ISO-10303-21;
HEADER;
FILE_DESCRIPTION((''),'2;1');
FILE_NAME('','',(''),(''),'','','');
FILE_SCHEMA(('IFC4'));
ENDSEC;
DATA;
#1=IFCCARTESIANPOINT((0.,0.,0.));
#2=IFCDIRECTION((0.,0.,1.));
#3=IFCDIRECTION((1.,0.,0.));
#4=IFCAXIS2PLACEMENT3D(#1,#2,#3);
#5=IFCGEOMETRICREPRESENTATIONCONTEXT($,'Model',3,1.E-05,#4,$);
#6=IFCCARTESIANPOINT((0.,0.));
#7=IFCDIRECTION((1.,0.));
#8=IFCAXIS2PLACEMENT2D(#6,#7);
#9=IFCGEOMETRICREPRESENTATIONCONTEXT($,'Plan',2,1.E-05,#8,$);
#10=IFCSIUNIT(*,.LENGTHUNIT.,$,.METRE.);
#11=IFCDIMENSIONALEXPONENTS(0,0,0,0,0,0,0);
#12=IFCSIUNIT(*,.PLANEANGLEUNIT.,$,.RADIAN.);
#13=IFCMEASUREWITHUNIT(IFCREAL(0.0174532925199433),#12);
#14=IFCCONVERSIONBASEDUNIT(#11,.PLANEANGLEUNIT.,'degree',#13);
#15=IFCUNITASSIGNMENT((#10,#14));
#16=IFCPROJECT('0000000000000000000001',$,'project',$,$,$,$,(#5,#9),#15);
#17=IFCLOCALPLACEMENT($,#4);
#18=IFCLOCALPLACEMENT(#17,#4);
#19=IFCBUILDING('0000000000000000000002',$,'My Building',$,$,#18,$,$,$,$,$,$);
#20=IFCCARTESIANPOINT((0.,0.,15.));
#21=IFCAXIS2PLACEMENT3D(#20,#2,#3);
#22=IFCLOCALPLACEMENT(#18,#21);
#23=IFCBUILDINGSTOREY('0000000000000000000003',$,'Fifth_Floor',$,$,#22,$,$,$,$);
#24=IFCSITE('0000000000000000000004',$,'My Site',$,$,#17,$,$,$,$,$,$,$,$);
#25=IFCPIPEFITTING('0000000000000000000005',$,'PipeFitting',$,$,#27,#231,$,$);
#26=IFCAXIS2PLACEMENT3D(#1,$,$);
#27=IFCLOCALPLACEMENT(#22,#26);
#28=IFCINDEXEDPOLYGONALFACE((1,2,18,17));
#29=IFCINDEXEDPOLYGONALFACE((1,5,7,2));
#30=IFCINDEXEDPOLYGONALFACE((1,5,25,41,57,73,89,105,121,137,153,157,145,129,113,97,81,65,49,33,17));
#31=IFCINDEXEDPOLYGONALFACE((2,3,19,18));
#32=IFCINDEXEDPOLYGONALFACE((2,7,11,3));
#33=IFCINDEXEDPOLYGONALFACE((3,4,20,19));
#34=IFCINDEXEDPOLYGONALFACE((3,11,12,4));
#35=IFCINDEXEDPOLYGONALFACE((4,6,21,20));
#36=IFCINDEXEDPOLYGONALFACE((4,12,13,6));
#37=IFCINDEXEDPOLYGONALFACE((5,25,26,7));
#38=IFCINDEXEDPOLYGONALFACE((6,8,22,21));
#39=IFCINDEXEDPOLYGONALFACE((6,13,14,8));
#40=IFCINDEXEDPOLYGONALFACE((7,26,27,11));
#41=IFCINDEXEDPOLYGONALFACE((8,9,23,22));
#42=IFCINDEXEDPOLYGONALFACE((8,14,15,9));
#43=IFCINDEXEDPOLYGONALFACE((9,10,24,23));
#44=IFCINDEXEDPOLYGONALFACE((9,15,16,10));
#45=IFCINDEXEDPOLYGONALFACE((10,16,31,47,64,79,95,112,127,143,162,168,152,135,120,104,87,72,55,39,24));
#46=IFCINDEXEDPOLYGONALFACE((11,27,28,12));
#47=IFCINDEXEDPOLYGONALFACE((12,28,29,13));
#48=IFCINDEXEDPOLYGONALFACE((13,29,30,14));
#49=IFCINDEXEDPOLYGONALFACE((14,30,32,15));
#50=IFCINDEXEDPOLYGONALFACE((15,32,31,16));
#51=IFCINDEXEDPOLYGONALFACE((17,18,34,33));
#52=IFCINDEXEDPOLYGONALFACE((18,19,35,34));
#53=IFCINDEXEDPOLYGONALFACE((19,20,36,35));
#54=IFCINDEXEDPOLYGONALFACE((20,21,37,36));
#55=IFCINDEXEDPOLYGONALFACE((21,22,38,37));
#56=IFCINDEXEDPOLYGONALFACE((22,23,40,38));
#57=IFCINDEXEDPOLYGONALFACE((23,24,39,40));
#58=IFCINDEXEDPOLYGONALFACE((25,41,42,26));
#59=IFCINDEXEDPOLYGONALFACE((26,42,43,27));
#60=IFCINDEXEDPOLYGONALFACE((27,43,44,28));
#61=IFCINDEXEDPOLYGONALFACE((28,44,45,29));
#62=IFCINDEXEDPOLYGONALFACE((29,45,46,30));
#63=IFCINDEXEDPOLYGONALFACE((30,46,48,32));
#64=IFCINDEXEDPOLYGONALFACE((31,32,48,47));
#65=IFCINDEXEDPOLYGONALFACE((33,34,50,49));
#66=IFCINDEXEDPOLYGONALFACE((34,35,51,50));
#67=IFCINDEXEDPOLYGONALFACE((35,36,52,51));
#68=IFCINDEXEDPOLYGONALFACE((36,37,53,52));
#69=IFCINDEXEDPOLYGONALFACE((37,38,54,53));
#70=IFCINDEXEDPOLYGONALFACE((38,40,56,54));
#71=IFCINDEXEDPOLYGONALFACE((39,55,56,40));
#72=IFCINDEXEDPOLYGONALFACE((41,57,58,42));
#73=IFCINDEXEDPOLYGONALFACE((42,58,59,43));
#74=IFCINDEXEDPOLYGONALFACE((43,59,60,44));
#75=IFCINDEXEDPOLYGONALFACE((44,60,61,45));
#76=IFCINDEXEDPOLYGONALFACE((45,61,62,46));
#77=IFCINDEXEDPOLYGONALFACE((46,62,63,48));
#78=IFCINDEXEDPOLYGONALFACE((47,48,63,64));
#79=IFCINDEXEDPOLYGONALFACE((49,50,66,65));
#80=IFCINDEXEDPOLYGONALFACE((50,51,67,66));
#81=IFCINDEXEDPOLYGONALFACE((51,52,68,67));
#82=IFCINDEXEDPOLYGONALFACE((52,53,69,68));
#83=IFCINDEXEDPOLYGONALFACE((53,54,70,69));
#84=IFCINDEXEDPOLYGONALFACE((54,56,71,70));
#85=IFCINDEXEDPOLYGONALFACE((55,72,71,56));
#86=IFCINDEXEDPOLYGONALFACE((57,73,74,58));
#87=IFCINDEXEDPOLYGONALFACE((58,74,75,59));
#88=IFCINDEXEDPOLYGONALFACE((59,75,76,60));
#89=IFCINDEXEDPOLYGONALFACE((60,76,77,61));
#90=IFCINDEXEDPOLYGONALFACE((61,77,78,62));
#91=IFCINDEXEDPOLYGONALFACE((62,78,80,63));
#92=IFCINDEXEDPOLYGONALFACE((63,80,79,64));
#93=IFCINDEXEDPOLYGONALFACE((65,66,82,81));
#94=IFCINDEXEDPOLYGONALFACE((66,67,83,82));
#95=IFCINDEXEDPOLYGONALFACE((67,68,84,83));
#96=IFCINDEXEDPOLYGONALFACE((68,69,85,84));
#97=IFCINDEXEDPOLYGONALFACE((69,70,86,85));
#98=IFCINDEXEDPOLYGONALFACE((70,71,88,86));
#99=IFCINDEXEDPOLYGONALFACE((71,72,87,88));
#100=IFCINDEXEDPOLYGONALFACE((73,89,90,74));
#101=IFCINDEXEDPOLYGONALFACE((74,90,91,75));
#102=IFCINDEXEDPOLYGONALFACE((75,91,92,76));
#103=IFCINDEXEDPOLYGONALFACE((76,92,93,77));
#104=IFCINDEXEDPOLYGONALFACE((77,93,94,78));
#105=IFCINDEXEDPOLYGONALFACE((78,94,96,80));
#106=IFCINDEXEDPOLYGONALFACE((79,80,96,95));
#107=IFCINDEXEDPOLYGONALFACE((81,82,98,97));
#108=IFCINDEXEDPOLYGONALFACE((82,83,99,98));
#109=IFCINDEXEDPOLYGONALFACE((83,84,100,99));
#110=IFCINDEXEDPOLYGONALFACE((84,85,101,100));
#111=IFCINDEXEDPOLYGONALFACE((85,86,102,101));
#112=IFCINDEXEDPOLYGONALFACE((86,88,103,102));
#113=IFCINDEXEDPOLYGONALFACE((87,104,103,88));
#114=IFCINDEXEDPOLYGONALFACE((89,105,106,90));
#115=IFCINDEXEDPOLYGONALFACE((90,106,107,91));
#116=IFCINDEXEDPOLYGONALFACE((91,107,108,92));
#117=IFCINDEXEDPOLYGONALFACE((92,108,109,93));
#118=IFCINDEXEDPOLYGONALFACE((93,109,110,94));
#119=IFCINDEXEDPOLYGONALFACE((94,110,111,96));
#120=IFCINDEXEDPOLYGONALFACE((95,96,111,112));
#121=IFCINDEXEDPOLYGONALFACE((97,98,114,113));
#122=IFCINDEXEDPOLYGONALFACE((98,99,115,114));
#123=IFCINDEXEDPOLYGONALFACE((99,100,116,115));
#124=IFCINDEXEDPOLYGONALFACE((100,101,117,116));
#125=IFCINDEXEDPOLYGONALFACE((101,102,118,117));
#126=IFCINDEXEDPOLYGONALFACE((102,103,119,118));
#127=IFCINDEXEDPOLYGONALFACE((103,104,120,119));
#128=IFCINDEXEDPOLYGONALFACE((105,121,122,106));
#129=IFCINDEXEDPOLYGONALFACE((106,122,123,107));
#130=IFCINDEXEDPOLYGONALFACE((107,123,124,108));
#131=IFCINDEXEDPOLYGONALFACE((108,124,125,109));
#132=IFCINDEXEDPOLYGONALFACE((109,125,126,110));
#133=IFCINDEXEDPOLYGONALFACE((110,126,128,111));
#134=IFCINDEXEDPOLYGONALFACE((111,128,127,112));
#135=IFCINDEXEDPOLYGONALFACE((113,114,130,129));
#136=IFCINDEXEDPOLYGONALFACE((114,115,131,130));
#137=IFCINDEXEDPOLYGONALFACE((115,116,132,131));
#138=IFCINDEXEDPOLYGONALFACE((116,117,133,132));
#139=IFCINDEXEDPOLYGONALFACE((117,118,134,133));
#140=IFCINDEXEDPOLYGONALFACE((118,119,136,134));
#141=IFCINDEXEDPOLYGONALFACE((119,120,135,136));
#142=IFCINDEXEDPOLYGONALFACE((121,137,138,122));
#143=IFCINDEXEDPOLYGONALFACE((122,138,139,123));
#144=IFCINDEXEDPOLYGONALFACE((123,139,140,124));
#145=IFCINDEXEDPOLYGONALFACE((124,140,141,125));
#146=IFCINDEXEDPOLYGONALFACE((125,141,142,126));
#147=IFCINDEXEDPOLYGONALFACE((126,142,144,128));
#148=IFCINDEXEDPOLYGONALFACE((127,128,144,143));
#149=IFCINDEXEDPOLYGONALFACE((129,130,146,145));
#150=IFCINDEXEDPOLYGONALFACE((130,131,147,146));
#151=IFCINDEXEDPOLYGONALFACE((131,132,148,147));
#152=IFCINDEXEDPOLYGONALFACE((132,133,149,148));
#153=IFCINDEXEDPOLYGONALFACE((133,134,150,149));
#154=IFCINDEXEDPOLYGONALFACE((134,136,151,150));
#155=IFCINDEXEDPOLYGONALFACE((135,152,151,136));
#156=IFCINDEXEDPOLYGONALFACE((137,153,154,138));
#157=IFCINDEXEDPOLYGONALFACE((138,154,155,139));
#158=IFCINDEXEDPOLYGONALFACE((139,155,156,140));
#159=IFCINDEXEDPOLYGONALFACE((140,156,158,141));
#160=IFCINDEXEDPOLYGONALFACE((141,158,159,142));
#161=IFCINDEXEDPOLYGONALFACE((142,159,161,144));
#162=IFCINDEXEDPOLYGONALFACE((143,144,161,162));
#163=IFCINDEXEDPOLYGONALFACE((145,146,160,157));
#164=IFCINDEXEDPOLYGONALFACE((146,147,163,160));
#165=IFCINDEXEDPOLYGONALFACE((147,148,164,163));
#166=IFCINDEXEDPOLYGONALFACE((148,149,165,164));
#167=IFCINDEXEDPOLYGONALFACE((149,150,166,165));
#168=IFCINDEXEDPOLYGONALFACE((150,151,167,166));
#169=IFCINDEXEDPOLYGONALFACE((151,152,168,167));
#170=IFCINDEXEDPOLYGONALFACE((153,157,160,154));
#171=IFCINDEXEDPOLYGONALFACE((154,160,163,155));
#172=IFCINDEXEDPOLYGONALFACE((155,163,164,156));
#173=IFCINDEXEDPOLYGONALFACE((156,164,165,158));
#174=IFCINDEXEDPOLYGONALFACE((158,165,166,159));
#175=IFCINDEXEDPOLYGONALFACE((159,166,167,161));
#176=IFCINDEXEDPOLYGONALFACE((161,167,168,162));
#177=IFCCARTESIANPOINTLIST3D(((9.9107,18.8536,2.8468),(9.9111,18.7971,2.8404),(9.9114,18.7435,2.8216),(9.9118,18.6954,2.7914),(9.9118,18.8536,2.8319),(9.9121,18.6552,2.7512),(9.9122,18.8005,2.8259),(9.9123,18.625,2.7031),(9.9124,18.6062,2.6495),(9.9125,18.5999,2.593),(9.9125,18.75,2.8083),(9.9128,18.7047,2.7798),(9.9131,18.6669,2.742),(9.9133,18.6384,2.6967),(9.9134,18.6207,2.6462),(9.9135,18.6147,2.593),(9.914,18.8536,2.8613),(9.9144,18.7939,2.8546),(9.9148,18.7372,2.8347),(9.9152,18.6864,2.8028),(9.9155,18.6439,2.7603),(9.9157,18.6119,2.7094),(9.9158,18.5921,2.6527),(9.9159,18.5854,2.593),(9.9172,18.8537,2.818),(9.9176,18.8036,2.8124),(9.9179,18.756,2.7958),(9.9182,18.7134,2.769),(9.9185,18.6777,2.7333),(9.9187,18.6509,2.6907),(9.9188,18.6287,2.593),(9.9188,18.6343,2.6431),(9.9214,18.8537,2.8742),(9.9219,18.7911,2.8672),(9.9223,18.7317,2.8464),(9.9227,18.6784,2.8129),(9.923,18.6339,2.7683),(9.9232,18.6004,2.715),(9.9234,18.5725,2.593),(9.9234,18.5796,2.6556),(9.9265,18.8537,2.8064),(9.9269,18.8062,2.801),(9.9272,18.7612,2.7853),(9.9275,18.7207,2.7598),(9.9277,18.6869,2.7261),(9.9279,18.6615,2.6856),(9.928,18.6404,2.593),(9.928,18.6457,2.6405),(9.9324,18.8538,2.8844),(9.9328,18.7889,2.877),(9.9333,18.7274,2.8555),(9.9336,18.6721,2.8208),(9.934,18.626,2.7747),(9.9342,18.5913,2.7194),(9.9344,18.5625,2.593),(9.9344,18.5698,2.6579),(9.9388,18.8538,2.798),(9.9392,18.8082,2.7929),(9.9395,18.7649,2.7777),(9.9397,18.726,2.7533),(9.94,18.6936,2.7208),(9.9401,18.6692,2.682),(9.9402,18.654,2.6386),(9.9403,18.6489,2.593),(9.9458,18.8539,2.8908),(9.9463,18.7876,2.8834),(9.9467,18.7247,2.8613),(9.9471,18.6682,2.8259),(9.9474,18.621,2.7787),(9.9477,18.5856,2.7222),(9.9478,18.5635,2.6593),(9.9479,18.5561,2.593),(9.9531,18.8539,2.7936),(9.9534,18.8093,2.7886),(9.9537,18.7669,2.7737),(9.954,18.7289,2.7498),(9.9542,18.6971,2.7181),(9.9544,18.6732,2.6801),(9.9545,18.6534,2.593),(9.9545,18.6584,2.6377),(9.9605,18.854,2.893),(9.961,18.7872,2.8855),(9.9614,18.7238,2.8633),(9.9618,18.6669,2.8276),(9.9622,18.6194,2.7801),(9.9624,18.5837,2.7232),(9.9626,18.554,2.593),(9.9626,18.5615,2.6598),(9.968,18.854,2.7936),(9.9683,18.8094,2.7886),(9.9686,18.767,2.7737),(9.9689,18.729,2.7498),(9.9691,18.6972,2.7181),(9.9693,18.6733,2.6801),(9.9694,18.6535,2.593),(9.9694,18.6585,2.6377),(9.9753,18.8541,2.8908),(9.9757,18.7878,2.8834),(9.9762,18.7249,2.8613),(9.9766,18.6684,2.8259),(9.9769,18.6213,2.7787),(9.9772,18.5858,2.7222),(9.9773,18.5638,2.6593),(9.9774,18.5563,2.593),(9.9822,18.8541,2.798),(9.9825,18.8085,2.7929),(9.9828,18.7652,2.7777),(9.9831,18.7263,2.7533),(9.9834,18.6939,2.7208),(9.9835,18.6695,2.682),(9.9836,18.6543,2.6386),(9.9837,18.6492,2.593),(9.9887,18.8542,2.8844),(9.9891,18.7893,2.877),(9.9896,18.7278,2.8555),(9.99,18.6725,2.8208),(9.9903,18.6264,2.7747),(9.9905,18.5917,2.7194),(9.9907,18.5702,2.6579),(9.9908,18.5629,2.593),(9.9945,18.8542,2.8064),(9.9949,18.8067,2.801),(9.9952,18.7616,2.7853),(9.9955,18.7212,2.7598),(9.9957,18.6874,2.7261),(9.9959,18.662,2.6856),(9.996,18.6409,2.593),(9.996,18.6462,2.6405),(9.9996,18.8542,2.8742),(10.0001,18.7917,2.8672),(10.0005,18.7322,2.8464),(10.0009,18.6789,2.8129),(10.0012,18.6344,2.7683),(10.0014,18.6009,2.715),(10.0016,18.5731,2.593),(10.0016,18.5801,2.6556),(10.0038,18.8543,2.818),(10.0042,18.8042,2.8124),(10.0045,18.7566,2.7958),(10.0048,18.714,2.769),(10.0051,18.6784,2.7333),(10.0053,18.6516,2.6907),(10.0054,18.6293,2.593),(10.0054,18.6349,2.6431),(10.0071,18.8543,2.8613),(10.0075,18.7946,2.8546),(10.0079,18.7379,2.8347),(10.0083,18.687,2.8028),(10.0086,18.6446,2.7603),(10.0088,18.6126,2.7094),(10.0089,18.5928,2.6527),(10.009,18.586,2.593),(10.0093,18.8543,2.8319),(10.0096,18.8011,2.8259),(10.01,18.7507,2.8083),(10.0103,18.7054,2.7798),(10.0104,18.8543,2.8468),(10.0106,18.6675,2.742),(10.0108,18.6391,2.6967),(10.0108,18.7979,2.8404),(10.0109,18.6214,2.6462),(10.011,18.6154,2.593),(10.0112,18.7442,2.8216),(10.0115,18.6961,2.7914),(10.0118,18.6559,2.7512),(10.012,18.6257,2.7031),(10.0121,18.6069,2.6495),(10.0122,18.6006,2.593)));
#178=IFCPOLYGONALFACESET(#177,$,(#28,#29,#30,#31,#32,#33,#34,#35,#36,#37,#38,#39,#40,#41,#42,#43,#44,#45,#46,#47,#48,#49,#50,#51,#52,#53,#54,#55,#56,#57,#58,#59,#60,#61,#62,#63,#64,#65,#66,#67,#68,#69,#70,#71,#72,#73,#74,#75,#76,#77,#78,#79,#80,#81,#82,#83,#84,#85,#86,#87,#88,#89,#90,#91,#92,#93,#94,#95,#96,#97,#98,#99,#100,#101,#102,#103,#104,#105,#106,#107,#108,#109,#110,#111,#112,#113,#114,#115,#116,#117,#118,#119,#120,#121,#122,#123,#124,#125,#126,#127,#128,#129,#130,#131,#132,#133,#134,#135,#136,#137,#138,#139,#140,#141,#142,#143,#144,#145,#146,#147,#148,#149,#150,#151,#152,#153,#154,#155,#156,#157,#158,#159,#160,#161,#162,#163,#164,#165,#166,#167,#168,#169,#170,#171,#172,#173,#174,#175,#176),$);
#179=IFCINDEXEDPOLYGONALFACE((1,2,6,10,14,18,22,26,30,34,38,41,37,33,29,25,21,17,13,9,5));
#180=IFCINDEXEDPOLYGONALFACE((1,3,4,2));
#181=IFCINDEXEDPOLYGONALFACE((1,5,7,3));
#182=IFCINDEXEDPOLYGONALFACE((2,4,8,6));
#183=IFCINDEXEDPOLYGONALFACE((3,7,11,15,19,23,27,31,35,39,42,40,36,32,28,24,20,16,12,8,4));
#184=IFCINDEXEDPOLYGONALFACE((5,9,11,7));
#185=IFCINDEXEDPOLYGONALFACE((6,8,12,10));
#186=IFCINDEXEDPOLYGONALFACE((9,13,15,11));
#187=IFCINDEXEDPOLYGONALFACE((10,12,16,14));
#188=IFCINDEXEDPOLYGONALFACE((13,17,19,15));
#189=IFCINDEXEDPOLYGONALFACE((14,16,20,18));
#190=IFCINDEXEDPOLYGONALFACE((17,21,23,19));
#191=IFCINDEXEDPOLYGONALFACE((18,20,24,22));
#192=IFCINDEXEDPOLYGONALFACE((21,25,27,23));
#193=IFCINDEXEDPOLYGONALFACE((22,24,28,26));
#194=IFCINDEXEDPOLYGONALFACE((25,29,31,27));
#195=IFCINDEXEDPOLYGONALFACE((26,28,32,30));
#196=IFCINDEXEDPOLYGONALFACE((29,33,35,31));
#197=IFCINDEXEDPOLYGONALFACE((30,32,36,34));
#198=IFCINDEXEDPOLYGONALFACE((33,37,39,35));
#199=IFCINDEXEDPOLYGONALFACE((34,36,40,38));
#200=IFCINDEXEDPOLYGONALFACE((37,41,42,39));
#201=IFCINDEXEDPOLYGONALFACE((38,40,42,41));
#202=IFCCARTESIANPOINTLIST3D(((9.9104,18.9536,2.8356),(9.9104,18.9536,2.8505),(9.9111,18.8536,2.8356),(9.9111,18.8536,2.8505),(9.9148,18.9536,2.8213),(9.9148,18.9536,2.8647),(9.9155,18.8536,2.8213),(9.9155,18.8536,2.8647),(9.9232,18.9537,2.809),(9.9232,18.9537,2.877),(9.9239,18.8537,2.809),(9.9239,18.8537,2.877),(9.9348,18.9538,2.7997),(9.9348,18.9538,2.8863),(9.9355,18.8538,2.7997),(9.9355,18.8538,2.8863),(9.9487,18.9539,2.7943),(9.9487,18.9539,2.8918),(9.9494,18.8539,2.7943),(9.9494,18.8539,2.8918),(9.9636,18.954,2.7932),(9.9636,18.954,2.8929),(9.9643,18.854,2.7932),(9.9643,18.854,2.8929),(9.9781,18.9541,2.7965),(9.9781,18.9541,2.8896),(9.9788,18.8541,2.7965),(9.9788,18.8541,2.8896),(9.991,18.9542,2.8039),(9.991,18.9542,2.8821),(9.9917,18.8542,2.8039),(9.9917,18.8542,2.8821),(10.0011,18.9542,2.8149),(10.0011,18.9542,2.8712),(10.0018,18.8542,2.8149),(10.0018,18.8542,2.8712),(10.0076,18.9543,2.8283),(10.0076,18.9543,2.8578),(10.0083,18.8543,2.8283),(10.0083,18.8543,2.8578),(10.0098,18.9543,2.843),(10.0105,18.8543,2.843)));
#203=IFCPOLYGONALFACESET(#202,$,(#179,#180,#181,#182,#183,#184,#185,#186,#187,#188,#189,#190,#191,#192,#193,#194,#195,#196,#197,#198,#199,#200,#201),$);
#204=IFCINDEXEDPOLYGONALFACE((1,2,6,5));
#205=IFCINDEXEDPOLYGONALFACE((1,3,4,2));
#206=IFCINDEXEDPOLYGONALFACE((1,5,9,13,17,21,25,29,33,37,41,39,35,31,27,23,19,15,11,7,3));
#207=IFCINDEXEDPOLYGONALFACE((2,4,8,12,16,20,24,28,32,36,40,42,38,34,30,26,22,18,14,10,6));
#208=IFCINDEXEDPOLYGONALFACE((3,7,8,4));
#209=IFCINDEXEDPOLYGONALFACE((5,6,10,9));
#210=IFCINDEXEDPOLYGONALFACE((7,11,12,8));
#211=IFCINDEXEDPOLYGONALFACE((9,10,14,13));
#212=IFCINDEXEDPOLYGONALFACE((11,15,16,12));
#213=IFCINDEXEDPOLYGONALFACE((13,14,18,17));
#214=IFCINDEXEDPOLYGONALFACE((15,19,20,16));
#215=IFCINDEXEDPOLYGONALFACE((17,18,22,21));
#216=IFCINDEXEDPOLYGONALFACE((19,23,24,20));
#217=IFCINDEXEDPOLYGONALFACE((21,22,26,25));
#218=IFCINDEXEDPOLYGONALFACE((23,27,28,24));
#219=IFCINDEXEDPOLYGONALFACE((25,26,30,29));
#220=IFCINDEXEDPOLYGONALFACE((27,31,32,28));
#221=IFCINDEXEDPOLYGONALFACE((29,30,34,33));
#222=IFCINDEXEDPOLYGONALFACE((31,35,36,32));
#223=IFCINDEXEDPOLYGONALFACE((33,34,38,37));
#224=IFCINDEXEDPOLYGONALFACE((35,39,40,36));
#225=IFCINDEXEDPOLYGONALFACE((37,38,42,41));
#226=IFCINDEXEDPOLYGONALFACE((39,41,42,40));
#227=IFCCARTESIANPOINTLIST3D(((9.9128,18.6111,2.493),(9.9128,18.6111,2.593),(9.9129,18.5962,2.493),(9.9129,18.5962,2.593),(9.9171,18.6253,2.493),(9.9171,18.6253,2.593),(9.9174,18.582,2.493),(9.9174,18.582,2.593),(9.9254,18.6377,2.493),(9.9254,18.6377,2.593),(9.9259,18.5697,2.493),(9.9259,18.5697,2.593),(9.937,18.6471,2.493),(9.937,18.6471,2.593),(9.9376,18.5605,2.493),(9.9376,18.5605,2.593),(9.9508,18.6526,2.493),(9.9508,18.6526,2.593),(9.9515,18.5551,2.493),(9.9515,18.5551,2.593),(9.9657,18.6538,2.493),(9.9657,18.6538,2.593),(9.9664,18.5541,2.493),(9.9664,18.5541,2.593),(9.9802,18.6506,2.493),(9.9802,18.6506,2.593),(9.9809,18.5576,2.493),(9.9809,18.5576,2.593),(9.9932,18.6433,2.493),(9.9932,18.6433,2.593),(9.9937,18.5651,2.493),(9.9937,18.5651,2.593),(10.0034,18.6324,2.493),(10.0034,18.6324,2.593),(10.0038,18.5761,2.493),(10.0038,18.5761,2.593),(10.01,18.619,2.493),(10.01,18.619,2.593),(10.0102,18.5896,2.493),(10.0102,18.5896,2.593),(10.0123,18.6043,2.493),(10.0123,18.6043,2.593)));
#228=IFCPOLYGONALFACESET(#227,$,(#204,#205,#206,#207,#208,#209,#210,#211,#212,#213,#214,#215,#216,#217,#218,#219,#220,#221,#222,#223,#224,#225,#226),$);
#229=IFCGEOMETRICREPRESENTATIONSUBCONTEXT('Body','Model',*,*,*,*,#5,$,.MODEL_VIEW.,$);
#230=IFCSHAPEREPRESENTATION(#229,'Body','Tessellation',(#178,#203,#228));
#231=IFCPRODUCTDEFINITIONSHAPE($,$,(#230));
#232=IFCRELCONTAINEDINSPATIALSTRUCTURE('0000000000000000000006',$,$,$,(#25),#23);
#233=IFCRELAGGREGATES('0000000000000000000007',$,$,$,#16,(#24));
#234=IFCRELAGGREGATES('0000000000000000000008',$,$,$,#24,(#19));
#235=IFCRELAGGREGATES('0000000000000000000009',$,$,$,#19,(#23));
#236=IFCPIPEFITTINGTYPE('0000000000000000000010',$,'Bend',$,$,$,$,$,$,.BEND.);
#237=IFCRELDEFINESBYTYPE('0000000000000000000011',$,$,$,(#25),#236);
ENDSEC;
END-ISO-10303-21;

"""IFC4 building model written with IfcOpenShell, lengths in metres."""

from ifc_helpers import new_model, entity, si_unit, converted_unit, frame, origin_with_axes, origin_2d_with_axis, place, context, subcontext, project, spatial, circle, extrude, source, transform, mapped, type_object, type_shapes, element, save


model = new_model("IFC4")

# Units and contexts
model_context = context("Model", 3, precision=1e-05, world=origin_with_axes())
plan_context = context("Plan", 2, precision=1e-05, world=origin_2d_with_axis())
body_context_1 = subcontext(model_context, "Body", "Model", "MODEL_VIEW")
ifc_project = project(units=[si_unit("LENGTHUNIT", "METRE"), converted_unit("PLANEANGLEUNIT", "degree", entity("IfcReal", 0.0174532925199433), si_unit("PLANEANGLEUNIT", "RADIAN"), dimensions=[0, 0, 0, 0, 0, 0, 0])], contexts=[model_context, plan_context])

# Site, building, storey
site_placement = place(None, origin_with_axes())
site = spatial("IfcSite", under=ifc_project, at=site_placement, Name="My Site")
building_placement = place(site_placement, origin_with_axes())
building = spatial("IfcBuilding", under=site, at=building_placement, Name="My Building")
storey_placement = place(building_placement, frame((0.0, 0.0, 15.0), z_axis=(0.0, 0.0, 1.0), x_axis=(1.0, 0.0, 0.0)))
storey = spatial("IfcBuildingStorey", under=building, at=storey_placement, Name="Fifth_Floor")

# Pipe fitting
pipe_fitting_type = type_object("IfcPipeFittingType", Name="Bend", PredefinedType="BEND")
shared_shape_1 = source(origin_with_axes(), body_context_1, "Body", "SolidModel", [
    entity("IfcSweptDiskSolid", entity("IfcIndexedPolyCurve", entity("IfcCartesianPointList3D", [[0.0, 0.0, -0.1], [0.0, 0.0732, -0.2768], [0.0, 0.25, -0.35]]), [entity("IfcArcIndex", [1, 2, 3])]), 0.05),
    extrude(circle(Radius=0.05), origin_with_axes(), (0.0, 0.0, -1.0), 0.1),
    extrude(circle(Radius=0.05), frame((0.0, 0.25, -0.35), z_axis=(0.0, 1.0, 0.0), x_axis=(1.0, 0.0, 0.0)), (0.0, 0.0, 1.0), 0.1),
])
type_shapes(pipe_fitting_type, [shared_shape_1])
for number, where, z_axis, x_axis, name in (
    (1, (9.9598, 18.954, 2.843), (-0.007084, 0.999975, 0.0), (0.999975, 0.007084, 0.0), "PipeFitting"),
):
    element("IfcPipeFitting", number, at=place(storey_placement, frame(where, z_axis=z_axis, x_axis=x_axis)), inside=storey, type_object=pipe_fitting_type, Name=name, context=body_context_1, shape_type="MappedRepresentation", body=[
        mapped(shared_shape_1, transform((0.0, 0.0, 0.0), x_axis=(1.0, 0.0, 0.0), y_axis=(0.0, 1.0, 0.0), z_axis=(0.0, 0.0, 1.0), scale=1.0)),
    ])

save(model, "model.ifc")
